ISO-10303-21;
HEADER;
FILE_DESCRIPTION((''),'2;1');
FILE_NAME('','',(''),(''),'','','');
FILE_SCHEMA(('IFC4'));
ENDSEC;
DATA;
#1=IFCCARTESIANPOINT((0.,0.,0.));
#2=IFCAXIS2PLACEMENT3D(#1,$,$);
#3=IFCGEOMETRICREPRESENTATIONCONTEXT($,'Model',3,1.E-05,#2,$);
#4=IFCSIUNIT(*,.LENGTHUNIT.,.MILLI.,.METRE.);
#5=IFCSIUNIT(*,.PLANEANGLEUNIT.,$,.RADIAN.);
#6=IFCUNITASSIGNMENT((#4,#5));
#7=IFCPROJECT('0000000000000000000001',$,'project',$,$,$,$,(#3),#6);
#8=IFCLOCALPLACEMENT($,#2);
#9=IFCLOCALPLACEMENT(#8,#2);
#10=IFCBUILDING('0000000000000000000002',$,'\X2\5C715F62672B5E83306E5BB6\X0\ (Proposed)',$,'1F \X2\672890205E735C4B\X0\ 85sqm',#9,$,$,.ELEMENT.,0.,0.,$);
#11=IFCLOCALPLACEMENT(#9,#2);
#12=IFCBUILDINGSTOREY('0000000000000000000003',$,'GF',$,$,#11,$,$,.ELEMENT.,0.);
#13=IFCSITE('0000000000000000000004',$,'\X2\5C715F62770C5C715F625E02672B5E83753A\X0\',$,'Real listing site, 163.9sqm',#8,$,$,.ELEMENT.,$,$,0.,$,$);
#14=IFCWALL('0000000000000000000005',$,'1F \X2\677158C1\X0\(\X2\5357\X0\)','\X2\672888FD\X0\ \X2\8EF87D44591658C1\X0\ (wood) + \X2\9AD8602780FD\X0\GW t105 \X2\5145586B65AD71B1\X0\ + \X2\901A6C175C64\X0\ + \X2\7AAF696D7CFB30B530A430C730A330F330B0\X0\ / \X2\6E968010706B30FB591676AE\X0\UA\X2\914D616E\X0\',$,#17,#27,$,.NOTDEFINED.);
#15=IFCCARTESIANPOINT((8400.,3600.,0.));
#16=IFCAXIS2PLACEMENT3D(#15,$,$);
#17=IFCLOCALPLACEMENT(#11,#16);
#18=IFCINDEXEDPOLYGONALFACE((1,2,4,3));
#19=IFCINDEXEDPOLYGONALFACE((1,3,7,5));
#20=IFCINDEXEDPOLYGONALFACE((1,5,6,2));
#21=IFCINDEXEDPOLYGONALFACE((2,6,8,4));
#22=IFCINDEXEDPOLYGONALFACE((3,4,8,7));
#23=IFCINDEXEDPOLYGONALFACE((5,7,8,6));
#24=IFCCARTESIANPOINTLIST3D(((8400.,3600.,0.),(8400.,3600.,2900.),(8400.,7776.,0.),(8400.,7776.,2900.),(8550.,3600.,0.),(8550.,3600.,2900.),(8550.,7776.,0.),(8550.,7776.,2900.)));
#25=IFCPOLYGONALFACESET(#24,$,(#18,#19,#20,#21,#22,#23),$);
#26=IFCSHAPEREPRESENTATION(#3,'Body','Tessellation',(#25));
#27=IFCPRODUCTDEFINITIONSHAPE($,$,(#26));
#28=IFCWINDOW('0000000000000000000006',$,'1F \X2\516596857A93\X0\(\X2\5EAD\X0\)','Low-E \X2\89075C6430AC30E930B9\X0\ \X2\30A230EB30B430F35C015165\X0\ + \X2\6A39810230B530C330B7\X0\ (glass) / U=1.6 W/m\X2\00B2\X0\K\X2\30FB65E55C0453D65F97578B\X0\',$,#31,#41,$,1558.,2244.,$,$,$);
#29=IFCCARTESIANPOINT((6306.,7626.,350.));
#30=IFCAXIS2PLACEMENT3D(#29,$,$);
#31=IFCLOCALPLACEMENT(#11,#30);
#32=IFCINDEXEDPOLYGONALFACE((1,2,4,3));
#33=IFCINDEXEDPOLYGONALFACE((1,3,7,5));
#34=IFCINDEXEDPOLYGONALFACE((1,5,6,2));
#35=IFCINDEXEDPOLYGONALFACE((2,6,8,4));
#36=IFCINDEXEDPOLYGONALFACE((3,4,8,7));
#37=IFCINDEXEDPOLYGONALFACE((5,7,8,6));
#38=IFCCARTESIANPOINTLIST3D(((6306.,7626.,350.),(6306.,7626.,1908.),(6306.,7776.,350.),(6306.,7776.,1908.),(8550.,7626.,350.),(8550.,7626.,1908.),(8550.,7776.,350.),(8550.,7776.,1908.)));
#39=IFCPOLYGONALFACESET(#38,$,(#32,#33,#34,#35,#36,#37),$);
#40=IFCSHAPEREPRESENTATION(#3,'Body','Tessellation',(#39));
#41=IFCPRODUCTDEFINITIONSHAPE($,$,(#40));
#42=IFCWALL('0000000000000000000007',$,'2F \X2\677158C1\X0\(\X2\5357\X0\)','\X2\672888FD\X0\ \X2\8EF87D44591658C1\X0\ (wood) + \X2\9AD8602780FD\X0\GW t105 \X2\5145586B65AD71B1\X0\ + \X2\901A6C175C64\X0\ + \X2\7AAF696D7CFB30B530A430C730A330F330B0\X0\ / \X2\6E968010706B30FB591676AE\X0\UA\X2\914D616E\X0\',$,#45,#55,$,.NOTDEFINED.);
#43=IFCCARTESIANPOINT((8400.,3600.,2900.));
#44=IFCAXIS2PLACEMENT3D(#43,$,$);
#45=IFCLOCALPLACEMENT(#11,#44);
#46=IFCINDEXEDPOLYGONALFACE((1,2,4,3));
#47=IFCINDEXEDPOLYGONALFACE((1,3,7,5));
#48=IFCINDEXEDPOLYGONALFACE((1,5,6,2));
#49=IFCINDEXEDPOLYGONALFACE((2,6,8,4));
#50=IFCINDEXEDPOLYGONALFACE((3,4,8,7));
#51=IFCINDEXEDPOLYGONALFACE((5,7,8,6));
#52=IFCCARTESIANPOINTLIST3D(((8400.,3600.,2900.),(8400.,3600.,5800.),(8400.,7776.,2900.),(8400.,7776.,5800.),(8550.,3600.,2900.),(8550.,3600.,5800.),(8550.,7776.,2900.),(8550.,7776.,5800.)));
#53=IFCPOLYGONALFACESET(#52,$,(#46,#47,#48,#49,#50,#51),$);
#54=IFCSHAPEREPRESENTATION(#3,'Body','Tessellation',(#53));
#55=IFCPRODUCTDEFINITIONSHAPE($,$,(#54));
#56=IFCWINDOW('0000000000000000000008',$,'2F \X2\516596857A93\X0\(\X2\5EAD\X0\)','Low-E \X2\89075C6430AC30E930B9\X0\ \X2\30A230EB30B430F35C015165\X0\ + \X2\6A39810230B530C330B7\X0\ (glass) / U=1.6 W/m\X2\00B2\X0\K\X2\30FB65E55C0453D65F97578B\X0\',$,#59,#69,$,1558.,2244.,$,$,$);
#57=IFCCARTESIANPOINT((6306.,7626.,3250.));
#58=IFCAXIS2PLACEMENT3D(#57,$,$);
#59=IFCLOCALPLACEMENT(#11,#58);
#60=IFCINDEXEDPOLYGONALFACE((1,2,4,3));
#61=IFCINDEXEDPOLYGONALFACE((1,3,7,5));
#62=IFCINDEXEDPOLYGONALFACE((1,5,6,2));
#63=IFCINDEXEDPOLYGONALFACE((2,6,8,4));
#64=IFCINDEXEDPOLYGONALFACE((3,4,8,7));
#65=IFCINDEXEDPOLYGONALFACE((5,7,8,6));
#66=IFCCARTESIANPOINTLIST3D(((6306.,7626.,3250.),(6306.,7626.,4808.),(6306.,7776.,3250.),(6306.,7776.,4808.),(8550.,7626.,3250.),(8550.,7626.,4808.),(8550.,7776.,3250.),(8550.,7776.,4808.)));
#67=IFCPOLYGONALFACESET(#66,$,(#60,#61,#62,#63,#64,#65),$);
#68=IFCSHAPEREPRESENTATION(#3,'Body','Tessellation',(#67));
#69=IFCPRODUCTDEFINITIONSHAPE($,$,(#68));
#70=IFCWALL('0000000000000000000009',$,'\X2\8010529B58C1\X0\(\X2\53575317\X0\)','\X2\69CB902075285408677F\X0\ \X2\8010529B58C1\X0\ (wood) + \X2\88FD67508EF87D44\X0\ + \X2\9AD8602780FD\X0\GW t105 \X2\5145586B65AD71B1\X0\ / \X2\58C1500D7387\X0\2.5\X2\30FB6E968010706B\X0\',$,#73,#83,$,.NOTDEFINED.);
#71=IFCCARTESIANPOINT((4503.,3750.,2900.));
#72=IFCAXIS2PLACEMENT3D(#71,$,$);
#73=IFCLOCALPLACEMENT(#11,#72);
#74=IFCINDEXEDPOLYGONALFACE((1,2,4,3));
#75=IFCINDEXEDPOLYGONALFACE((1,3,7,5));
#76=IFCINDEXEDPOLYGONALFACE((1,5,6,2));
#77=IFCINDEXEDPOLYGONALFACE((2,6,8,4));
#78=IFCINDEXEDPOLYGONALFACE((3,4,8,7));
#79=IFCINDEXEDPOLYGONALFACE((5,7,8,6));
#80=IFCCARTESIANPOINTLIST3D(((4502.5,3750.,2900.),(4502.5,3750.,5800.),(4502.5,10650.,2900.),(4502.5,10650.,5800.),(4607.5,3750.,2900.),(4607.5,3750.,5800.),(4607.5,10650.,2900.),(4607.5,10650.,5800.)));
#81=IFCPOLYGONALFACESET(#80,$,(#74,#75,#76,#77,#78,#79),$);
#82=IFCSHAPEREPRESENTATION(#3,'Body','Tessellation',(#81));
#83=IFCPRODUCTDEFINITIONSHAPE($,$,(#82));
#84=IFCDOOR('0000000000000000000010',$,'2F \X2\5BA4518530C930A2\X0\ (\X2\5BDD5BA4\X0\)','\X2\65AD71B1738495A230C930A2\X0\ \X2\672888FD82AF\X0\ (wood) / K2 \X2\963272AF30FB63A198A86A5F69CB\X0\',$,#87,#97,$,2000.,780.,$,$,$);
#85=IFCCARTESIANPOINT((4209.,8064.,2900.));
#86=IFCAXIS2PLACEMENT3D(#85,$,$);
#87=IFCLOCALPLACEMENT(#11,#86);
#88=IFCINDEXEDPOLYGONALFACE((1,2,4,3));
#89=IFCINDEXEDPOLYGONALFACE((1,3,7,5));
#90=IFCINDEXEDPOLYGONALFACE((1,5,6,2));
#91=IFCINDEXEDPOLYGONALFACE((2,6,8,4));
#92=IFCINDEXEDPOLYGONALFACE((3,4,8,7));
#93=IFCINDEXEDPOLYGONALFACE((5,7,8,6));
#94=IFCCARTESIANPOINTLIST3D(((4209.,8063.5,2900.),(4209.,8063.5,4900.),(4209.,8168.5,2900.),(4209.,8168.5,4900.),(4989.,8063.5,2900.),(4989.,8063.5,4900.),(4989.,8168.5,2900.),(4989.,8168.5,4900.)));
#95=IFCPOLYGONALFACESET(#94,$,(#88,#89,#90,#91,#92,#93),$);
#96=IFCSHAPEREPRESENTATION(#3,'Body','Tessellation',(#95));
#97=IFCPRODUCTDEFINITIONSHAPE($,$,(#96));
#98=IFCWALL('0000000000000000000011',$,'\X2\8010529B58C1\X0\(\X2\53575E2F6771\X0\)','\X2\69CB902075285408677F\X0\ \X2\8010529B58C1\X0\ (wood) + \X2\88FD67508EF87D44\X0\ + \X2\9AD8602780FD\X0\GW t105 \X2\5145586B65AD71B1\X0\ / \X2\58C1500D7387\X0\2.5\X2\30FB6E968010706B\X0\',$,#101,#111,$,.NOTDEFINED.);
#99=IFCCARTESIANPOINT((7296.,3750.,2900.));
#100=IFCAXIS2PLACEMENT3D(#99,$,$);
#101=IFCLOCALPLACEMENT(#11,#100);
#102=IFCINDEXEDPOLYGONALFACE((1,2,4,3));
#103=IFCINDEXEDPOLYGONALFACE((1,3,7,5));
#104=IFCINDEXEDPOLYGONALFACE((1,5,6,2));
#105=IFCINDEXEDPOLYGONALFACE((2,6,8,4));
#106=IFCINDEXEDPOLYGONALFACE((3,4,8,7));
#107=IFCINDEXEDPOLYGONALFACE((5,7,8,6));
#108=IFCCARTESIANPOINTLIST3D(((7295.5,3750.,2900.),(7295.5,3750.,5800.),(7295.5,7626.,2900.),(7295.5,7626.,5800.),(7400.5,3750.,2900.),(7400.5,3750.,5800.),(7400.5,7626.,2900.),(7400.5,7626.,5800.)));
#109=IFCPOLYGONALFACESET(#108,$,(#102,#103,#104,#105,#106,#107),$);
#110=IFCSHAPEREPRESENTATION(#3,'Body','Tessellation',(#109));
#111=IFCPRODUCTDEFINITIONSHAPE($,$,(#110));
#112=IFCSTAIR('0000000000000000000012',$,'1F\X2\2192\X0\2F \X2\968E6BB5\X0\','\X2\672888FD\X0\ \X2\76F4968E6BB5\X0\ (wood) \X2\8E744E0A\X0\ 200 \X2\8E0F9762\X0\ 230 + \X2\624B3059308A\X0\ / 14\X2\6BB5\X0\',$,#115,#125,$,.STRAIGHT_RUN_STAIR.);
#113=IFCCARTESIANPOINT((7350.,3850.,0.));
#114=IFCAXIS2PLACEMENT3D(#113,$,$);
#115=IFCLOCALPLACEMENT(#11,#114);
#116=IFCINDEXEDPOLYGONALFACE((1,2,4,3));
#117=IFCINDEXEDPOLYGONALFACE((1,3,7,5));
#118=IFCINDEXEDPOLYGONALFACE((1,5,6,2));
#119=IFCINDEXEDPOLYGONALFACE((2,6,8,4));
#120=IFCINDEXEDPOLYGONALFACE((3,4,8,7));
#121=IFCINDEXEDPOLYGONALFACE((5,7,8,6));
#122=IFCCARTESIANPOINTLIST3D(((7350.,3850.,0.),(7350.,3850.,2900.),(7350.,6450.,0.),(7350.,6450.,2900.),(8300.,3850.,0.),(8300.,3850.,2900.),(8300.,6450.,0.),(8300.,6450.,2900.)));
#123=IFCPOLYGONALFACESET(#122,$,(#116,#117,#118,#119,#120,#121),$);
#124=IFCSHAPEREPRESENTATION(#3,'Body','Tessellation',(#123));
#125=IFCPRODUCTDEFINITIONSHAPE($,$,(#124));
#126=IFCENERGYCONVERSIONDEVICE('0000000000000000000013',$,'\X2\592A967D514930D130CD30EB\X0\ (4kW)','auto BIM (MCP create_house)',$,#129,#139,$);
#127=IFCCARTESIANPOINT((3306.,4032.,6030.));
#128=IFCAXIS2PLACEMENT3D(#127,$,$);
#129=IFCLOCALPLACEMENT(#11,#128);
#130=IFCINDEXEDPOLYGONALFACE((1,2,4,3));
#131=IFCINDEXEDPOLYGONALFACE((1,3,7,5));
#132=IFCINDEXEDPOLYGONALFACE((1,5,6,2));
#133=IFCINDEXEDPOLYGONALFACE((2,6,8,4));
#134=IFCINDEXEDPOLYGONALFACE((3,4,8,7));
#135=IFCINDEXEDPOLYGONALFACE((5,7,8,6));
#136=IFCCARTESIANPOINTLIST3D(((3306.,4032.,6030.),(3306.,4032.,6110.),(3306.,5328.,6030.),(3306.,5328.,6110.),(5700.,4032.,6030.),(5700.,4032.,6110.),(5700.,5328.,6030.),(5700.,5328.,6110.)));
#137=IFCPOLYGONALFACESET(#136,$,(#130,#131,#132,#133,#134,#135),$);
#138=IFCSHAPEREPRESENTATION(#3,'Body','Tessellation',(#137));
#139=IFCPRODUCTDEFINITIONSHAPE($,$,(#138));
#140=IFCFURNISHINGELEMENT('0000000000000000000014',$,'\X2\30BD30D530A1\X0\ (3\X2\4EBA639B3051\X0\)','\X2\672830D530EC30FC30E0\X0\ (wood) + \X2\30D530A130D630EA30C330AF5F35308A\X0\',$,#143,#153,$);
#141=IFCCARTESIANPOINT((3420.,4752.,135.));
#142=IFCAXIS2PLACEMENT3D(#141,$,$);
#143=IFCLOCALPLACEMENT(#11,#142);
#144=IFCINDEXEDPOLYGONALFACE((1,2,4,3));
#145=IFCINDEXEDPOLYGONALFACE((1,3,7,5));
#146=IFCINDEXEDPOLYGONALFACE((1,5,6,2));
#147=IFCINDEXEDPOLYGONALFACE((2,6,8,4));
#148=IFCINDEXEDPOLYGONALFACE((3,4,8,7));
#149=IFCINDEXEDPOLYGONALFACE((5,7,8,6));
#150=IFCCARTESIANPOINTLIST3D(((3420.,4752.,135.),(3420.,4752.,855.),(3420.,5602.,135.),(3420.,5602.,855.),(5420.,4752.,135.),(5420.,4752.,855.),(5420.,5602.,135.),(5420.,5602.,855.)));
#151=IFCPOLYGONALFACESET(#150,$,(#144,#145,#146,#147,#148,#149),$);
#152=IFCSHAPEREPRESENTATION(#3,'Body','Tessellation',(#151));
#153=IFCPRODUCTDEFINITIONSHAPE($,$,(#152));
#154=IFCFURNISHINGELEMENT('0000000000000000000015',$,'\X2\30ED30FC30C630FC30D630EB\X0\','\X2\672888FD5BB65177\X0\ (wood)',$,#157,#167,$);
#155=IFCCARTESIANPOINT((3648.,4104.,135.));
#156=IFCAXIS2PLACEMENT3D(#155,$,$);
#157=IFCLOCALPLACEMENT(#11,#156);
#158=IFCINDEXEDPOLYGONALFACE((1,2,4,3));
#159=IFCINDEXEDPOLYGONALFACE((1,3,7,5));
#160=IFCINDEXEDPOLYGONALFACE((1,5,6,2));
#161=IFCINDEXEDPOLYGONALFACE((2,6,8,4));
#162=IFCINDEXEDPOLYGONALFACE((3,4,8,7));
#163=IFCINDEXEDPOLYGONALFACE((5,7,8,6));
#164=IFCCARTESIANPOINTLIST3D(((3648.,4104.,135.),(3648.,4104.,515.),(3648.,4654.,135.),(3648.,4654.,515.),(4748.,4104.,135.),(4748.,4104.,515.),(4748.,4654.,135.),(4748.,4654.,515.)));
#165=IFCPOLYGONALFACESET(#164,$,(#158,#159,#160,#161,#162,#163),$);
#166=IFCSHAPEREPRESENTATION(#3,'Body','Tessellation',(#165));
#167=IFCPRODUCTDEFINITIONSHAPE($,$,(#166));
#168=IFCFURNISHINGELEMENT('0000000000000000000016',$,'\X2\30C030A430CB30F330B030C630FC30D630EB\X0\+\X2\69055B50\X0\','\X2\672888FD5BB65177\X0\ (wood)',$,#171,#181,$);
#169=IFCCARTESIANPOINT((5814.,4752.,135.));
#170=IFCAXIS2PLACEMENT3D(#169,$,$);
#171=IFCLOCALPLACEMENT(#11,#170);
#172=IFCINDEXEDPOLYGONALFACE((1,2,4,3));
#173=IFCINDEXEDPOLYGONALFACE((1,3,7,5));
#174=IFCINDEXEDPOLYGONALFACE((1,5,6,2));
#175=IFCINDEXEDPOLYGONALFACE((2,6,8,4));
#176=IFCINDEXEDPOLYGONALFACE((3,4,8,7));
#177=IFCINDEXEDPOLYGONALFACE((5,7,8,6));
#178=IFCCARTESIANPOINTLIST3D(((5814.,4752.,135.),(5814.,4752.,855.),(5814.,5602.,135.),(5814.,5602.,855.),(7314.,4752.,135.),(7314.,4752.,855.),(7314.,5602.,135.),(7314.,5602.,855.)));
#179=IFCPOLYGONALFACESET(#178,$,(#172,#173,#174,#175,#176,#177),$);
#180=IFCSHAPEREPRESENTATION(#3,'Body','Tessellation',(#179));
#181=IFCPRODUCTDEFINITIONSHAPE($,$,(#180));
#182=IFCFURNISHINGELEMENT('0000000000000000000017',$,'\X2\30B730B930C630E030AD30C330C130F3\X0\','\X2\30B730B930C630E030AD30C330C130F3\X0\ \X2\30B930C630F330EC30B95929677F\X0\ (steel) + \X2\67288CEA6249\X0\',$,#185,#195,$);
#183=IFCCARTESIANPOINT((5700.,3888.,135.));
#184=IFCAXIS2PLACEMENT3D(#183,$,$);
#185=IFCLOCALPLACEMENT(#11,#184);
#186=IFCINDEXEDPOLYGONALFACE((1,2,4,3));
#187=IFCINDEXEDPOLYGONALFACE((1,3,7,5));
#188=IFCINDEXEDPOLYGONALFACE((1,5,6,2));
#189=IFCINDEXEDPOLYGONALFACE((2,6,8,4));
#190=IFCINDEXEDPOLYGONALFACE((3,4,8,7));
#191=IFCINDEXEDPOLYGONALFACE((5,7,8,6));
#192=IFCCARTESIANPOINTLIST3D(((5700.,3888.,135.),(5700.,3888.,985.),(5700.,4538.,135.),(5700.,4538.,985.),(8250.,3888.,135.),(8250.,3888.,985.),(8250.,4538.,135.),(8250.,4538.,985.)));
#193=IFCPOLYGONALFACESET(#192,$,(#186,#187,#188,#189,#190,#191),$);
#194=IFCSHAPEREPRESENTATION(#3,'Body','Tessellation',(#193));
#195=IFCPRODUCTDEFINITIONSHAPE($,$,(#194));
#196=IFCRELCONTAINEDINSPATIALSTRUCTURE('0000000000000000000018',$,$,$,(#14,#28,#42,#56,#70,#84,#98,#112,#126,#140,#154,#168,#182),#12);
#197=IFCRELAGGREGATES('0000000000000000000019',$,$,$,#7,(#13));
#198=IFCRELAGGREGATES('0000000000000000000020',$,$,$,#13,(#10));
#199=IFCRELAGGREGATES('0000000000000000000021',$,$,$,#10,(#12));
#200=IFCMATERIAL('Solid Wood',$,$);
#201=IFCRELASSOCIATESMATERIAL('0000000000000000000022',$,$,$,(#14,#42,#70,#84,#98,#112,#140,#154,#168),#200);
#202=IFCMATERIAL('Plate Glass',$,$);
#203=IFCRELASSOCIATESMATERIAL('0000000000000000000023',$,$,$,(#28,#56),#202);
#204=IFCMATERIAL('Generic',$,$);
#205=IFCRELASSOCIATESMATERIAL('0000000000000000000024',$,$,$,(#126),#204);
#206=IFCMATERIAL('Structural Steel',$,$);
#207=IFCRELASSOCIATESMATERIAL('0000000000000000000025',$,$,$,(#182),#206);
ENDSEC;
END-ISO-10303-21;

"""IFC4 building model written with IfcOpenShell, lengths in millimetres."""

from ifc_helpers import new_model, si_unit, frame, frame_2d, origin, place, context, project, spatial, rectangle, extrude, material, element, fill, save


model = new_model("IFC4")

# Units and contexts
model_context = context("Model", 3, precision=1e-05, world=origin())
ifc_project = project(units=[si_unit("LENGTHUNIT", "METRE", prefix="MILLI"), si_unit("PLANEANGLEUNIT", "RADIAN")], contexts=[model_context])

# Site, building, storey
site_placement = place(None, origin())
site = spatial("IfcSite", under=ifc_project, at=site_placement, Name="山形県山形市末広町", ObjectType="Real listing site, 163.9sqm", CompositionType="ELEMENT", RefElevation=0.0)
building_placement = place(site_placement, origin())
building = spatial("IfcBuilding", under=site, at=building_placement, Name="山形末広の家 (Proposed)", ObjectType="1F 木造平屋 85sqm", CompositionType="ELEMENT", ElevationOfRefHeight=0.0, ElevationOfTerrain=0.0)
storey_placement = place(building_placement, origin())
storey = spatial("IfcBuildingStorey", under=building, at=storey_placement, Name="GF", CompositionType="ELEMENT", Elevation=0.0)

# Wall, opening, window
ifc_material_1 = material(Name="Solid Wood")
wall_1_placement = place(storey_placement, frame((8400.0, 3600.0, 0.0)))
wall_1 = element("IfcWall", 1, at=wall_1_placement, inside=storey, material=ifc_material_1, Name="1F 東壁(南)", Description="木製 軸組外壁 (wood) + 高性能GW t105 充填断熱 + 通気層 + 窯業系サイディング / 準耐火・外皮UA配慮", PredefinedType="NOTDEFINED", context=model_context, shape_type="SweptSolid", body=[
    extrude(rectangle(XDim=150.0, YDim=4176.0, at=frame_2d((75.0, 2088.0))), frame((8400.0, 3600.0, 0.0)), (0.0, 0.0, 1.0), 2900.0),
])
opening_1_placement = place(storey_placement, frame((6306.0, 7626.0, 350.0)))
opening_1 = element("IfcOpeningElement", 2, at=opening_1_placement, cuts=wall_1, PredefinedType="NOTDEFINED", context=model_context, shape_type="SweptSolid", body=[
    extrude(rectangle(XDim=2244.0, YDim=150.0, at=frame_2d((1122.0, 75.0))), frame((6306.0, 7626.0, 350.0)), (0.0, 0.0, 1.0), 1558.0),
])
ifc_material_2 = material(Name="Plate Glass")
window_1_placement = place(storey_placement, frame((6306.0, 7626.0, 350.0)))
window_1 = element("IfcWindow", 3, at=window_1_placement, inside=storey, material=ifc_material_2, Name="1F 入隅窓(庭)", Description="Low-E 複層ガラス アルゴン封入 + 樹脂サッシ (glass) / U=1.6 W/m²K・日射取得型", OverallHeight=1558.0, OverallWidth=2244.0, context=model_context, shape_type="SweptSolid", body=[
    extrude(rectangle(XDim=2244.0, YDim=150.0, at=frame_2d((1122.0, 75.0))), frame((6306.0, 7626.0, 350.0)), (0.0, 0.0, 1.0), 1558.0),
])
fill(opening_1, window_1)

# Wall, opening, window
wall_2_placement = place(storey_placement, frame((8400.0, 3600.0, 2900.0)))
wall_2 = element("IfcWall", 4, at=wall_2_placement, inside=storey, material=ifc_material_1, Name="2F 東壁(南)", Description="木製 軸組外壁 (wood) + 高性能GW t105 充填断熱 + 通気層 + 窯業系サイディング / 準耐火・外皮UA配慮", PredefinedType="NOTDEFINED", context=model_context, shape_type="SweptSolid", body=[
    extrude(rectangle(XDim=150.0, YDim=4176.0, at=frame_2d((75.0, 2088.0))), frame((8400.0, 3600.0, 2900.0)), (0.0, 0.0, 1.0), 2900.0),
])
opening_2_placement = place(storey_placement, frame((6306.0, 7626.0, 3250.0)))
opening_2 = element("IfcOpeningElement", 5, at=opening_2_placement, cuts=wall_2, PredefinedType="NOTDEFINED", context=model_context, shape_type="SweptSolid", body=[
    extrude(rectangle(XDim=2244.0, YDim=150.0, at=frame_2d((1122.0, 75.0))), frame((6306.0, 7626.0, 3250.0)), (0.0, 0.0, 1.0), 1558.0),
])
window_2_placement = place(storey_placement, frame((6306.0, 7626.0, 3250.0)))
window_2 = element("IfcWindow", 6, at=window_2_placement, inside=storey, material=ifc_material_2, Name="2F 入隅窓(庭)", Description="Low-E 複層ガラス アルゴン封入 + 樹脂サッシ (glass) / U=1.6 W/m²K・日射取得型", OverallHeight=1558.0, OverallWidth=2244.0, context=model_context, shape_type="SweptSolid", body=[
    extrude(rectangle(XDim=2244.0, YDim=150.0, at=frame_2d((1122.0, 75.0))), frame((6306.0, 7626.0, 3250.0)), (0.0, 0.0, 1.0), 1558.0),
])
fill(opening_2, window_2)

# Wall, opening, door
wall_3_placement = place(storey_placement, frame((4503.0, 3750.0, 2900.0)))
wall_3 = element("IfcWall", 7, at=wall_3_placement, inside=storey, material=ifc_material_1, Name="耐力壁(南北)", Description="構造用合板 耐力壁 (wood) + 製材軸組 + 高性能GW t105 充填断熱 / 壁倍率2.5・準耐火", PredefinedType="NOTDEFINED", context=model_context, shape_type="SweptSolid", body=[
    extrude(rectangle(XDim=105.0, YDim=6900.0, at=frame_2d((52.0, 3450.0))), frame((4503.0, 3750.0, 2900.0)), (0.0, 0.0, 1.0), 2900.0),
])
opening_3_placement = place(storey_placement, frame((4209.0, 8064.0, 2900.0)))
opening_3 = element("IfcOpeningElement", 8, at=opening_3_placement, cuts=wall_3, PredefinedType="NOTDEFINED", context=model_context, shape_type="SweptSolid", body=[
    extrude(rectangle(XDim=780.0, YDim=105.0, at=frame_2d((390.0, 52.0))), frame((4209.0, 8064.0, 2900.0)), (0.0, 0.0, 1.0), 2000.0),
])
door_1_placement = place(storey_placement, frame((4209.0, 8064.0, 2900.0)))
door_1 = element("IfcDoor", 9, at=door_1_placement, inside=storey, material=ifc_material_1, Name="2F 室内ドア (寝室)", Description="断熱玄関ドア 木製芯 (wood) / K2 防犯・採風機構", OverallHeight=2000.0, OverallWidth=780.0, context=model_context, shape_type="SweptSolid", body=[
    extrude(rectangle(XDim=780.0, YDim=105.0, at=frame_2d((390.0, 52.0))), frame((4209.0, 8064.0, 2900.0)), (0.0, 0.0, 1.0), 2000.0),
])
fill(opening_3, door_1)

# Wall
wall_4_placement = place(storey_placement, frame((7296.0, 3750.0, 2900.0)))
element("IfcWall", 10, at=wall_4_placement, inside=storey, material=ifc_material_1, Name="耐力壁(南帯東)", Description="構造用合板 耐力壁 (wood) + 製材軸組 + 高性能GW t105 充填断熱 / 壁倍率2.5・準耐火", PredefinedType="NOTDEFINED", context=model_context, shape_type="SweptSolid", body=[
    extrude(rectangle(XDim=105.0, YDim=3876.0, at=frame_2d((52.0, 1938.0))), frame((7296.0, 3750.0, 2900.0)), (0.0, 0.0, 1.0), 2900.0),
])

# Stair
stair_placement = place(storey_placement, frame((7350.0, 3850.0, 0.0)))
element("IfcStair", 11, at=stair_placement, inside=storey, material=ifc_material_1, Name="1F→2F 階段", Description="木製 直階段 (wood) 蹴上 200 踏面 230 + 手すり / 14段", PredefinedType="STRAIGHT_RUN_STAIR", context=model_context, shape_type="SweptSolid", body=[
    extrude(rectangle(XDim=950.0, YDim=2600.0, at=frame_2d((475.0, 1300.0))), frame((7350.0, 3850.0, 0.0)), (0.0, 0.0, 1.0), 2900.0),
])

# Energy conversion device
ifc_material_3 = material(Name="Generic")
energy_conversion_device_placement = place(storey_placement, frame((3306.0, 4032.0, 6030.0)))
element("IfcEnergyConversionDevice", 12, at=energy_conversion_device_placement, inside=storey, material=ifc_material_3, Name="太陽光パネル (4kW)", Description="auto BIM (MCP create_house)", context=model_context, shape_type="SweptSolid", body=[
    extrude(rectangle(XDim=2394.0, YDim=1296.0, at=frame_2d((1197.0, 648.0))), frame((3306.0, 4032.0, 6030.0)), (0.0, 0.0, 1.0), 80.0),
])

# Furnishing elements
furnishing_1_placement = place(storey_placement, frame((3420.0, 4752.0, 135.0)))
element("IfcFurnishingElement", 13, at=furnishing_1_placement, inside=storey, material=ifc_material_1, Name="ソファ (3人掛け)", Description="木フレーム (wood) + ファブリック張り", context=model_context, shape_type="SweptSolid", body=[
    extrude(rectangle(XDim=2000.0, YDim=850.0, at=frame_2d((1000.0, 425.0))), frame((3420.0, 4752.0, 135.0)), (0.0, 0.0, 1.0), 720.0),
])
furnishing_2_placement = place(storey_placement, frame((3648.0, 4104.0, 135.0)))
element("IfcFurnishingElement", 14, at=furnishing_2_placement, inside=storey, material=ifc_material_1, Name="ローテーブル", Description="木製家具 (wood)", context=model_context, shape_type="SweptSolid", body=[
    extrude(rectangle(XDim=1100.0, YDim=550.0, at=frame_2d((550.0, 275.0))), frame((3648.0, 4104.0, 135.0)), (0.0, 0.0, 1.0), 380.0),
])
furnishing_3_placement = place(storey_placement, frame((5814.0, 4752.0, 135.0)))
element("IfcFurnishingElement", 15, at=furnishing_3_placement, inside=storey, material=ifc_material_1, Name="ダイニングテーブル+椅子", Description="木製家具 (wood)", context=model_context, shape_type="SweptSolid", body=[
    extrude(rectangle(XDim=1500.0, YDim=850.0, at=frame_2d((750.0, 425.0))), frame((5814.0, 4752.0, 135.0)), (0.0, 0.0, 1.0), 720.0),
])
ifc_material_4 = material(Name="Structural Steel")
furnishing_4_placement = place(storey_placement, frame((5700.0, 3888.0, 135.0)))
element("IfcFurnishingElement", 16, at=furnishing_4_placement, inside=storey, material=ifc_material_4, Name="システムキッチン", Description="システムキッチン ステンレス天板 (steel) + 木質扉", context=model_context, shape_type="SweptSolid", body=[
    extrude(rectangle(XDim=2550.0, YDim=650.0, at=frame_2d((1275.0, 325.0))), frame((5700.0, 3888.0, 135.0)), (0.0, 0.0, 1.0), 850.0),
])

save(model, "model.ifc")
